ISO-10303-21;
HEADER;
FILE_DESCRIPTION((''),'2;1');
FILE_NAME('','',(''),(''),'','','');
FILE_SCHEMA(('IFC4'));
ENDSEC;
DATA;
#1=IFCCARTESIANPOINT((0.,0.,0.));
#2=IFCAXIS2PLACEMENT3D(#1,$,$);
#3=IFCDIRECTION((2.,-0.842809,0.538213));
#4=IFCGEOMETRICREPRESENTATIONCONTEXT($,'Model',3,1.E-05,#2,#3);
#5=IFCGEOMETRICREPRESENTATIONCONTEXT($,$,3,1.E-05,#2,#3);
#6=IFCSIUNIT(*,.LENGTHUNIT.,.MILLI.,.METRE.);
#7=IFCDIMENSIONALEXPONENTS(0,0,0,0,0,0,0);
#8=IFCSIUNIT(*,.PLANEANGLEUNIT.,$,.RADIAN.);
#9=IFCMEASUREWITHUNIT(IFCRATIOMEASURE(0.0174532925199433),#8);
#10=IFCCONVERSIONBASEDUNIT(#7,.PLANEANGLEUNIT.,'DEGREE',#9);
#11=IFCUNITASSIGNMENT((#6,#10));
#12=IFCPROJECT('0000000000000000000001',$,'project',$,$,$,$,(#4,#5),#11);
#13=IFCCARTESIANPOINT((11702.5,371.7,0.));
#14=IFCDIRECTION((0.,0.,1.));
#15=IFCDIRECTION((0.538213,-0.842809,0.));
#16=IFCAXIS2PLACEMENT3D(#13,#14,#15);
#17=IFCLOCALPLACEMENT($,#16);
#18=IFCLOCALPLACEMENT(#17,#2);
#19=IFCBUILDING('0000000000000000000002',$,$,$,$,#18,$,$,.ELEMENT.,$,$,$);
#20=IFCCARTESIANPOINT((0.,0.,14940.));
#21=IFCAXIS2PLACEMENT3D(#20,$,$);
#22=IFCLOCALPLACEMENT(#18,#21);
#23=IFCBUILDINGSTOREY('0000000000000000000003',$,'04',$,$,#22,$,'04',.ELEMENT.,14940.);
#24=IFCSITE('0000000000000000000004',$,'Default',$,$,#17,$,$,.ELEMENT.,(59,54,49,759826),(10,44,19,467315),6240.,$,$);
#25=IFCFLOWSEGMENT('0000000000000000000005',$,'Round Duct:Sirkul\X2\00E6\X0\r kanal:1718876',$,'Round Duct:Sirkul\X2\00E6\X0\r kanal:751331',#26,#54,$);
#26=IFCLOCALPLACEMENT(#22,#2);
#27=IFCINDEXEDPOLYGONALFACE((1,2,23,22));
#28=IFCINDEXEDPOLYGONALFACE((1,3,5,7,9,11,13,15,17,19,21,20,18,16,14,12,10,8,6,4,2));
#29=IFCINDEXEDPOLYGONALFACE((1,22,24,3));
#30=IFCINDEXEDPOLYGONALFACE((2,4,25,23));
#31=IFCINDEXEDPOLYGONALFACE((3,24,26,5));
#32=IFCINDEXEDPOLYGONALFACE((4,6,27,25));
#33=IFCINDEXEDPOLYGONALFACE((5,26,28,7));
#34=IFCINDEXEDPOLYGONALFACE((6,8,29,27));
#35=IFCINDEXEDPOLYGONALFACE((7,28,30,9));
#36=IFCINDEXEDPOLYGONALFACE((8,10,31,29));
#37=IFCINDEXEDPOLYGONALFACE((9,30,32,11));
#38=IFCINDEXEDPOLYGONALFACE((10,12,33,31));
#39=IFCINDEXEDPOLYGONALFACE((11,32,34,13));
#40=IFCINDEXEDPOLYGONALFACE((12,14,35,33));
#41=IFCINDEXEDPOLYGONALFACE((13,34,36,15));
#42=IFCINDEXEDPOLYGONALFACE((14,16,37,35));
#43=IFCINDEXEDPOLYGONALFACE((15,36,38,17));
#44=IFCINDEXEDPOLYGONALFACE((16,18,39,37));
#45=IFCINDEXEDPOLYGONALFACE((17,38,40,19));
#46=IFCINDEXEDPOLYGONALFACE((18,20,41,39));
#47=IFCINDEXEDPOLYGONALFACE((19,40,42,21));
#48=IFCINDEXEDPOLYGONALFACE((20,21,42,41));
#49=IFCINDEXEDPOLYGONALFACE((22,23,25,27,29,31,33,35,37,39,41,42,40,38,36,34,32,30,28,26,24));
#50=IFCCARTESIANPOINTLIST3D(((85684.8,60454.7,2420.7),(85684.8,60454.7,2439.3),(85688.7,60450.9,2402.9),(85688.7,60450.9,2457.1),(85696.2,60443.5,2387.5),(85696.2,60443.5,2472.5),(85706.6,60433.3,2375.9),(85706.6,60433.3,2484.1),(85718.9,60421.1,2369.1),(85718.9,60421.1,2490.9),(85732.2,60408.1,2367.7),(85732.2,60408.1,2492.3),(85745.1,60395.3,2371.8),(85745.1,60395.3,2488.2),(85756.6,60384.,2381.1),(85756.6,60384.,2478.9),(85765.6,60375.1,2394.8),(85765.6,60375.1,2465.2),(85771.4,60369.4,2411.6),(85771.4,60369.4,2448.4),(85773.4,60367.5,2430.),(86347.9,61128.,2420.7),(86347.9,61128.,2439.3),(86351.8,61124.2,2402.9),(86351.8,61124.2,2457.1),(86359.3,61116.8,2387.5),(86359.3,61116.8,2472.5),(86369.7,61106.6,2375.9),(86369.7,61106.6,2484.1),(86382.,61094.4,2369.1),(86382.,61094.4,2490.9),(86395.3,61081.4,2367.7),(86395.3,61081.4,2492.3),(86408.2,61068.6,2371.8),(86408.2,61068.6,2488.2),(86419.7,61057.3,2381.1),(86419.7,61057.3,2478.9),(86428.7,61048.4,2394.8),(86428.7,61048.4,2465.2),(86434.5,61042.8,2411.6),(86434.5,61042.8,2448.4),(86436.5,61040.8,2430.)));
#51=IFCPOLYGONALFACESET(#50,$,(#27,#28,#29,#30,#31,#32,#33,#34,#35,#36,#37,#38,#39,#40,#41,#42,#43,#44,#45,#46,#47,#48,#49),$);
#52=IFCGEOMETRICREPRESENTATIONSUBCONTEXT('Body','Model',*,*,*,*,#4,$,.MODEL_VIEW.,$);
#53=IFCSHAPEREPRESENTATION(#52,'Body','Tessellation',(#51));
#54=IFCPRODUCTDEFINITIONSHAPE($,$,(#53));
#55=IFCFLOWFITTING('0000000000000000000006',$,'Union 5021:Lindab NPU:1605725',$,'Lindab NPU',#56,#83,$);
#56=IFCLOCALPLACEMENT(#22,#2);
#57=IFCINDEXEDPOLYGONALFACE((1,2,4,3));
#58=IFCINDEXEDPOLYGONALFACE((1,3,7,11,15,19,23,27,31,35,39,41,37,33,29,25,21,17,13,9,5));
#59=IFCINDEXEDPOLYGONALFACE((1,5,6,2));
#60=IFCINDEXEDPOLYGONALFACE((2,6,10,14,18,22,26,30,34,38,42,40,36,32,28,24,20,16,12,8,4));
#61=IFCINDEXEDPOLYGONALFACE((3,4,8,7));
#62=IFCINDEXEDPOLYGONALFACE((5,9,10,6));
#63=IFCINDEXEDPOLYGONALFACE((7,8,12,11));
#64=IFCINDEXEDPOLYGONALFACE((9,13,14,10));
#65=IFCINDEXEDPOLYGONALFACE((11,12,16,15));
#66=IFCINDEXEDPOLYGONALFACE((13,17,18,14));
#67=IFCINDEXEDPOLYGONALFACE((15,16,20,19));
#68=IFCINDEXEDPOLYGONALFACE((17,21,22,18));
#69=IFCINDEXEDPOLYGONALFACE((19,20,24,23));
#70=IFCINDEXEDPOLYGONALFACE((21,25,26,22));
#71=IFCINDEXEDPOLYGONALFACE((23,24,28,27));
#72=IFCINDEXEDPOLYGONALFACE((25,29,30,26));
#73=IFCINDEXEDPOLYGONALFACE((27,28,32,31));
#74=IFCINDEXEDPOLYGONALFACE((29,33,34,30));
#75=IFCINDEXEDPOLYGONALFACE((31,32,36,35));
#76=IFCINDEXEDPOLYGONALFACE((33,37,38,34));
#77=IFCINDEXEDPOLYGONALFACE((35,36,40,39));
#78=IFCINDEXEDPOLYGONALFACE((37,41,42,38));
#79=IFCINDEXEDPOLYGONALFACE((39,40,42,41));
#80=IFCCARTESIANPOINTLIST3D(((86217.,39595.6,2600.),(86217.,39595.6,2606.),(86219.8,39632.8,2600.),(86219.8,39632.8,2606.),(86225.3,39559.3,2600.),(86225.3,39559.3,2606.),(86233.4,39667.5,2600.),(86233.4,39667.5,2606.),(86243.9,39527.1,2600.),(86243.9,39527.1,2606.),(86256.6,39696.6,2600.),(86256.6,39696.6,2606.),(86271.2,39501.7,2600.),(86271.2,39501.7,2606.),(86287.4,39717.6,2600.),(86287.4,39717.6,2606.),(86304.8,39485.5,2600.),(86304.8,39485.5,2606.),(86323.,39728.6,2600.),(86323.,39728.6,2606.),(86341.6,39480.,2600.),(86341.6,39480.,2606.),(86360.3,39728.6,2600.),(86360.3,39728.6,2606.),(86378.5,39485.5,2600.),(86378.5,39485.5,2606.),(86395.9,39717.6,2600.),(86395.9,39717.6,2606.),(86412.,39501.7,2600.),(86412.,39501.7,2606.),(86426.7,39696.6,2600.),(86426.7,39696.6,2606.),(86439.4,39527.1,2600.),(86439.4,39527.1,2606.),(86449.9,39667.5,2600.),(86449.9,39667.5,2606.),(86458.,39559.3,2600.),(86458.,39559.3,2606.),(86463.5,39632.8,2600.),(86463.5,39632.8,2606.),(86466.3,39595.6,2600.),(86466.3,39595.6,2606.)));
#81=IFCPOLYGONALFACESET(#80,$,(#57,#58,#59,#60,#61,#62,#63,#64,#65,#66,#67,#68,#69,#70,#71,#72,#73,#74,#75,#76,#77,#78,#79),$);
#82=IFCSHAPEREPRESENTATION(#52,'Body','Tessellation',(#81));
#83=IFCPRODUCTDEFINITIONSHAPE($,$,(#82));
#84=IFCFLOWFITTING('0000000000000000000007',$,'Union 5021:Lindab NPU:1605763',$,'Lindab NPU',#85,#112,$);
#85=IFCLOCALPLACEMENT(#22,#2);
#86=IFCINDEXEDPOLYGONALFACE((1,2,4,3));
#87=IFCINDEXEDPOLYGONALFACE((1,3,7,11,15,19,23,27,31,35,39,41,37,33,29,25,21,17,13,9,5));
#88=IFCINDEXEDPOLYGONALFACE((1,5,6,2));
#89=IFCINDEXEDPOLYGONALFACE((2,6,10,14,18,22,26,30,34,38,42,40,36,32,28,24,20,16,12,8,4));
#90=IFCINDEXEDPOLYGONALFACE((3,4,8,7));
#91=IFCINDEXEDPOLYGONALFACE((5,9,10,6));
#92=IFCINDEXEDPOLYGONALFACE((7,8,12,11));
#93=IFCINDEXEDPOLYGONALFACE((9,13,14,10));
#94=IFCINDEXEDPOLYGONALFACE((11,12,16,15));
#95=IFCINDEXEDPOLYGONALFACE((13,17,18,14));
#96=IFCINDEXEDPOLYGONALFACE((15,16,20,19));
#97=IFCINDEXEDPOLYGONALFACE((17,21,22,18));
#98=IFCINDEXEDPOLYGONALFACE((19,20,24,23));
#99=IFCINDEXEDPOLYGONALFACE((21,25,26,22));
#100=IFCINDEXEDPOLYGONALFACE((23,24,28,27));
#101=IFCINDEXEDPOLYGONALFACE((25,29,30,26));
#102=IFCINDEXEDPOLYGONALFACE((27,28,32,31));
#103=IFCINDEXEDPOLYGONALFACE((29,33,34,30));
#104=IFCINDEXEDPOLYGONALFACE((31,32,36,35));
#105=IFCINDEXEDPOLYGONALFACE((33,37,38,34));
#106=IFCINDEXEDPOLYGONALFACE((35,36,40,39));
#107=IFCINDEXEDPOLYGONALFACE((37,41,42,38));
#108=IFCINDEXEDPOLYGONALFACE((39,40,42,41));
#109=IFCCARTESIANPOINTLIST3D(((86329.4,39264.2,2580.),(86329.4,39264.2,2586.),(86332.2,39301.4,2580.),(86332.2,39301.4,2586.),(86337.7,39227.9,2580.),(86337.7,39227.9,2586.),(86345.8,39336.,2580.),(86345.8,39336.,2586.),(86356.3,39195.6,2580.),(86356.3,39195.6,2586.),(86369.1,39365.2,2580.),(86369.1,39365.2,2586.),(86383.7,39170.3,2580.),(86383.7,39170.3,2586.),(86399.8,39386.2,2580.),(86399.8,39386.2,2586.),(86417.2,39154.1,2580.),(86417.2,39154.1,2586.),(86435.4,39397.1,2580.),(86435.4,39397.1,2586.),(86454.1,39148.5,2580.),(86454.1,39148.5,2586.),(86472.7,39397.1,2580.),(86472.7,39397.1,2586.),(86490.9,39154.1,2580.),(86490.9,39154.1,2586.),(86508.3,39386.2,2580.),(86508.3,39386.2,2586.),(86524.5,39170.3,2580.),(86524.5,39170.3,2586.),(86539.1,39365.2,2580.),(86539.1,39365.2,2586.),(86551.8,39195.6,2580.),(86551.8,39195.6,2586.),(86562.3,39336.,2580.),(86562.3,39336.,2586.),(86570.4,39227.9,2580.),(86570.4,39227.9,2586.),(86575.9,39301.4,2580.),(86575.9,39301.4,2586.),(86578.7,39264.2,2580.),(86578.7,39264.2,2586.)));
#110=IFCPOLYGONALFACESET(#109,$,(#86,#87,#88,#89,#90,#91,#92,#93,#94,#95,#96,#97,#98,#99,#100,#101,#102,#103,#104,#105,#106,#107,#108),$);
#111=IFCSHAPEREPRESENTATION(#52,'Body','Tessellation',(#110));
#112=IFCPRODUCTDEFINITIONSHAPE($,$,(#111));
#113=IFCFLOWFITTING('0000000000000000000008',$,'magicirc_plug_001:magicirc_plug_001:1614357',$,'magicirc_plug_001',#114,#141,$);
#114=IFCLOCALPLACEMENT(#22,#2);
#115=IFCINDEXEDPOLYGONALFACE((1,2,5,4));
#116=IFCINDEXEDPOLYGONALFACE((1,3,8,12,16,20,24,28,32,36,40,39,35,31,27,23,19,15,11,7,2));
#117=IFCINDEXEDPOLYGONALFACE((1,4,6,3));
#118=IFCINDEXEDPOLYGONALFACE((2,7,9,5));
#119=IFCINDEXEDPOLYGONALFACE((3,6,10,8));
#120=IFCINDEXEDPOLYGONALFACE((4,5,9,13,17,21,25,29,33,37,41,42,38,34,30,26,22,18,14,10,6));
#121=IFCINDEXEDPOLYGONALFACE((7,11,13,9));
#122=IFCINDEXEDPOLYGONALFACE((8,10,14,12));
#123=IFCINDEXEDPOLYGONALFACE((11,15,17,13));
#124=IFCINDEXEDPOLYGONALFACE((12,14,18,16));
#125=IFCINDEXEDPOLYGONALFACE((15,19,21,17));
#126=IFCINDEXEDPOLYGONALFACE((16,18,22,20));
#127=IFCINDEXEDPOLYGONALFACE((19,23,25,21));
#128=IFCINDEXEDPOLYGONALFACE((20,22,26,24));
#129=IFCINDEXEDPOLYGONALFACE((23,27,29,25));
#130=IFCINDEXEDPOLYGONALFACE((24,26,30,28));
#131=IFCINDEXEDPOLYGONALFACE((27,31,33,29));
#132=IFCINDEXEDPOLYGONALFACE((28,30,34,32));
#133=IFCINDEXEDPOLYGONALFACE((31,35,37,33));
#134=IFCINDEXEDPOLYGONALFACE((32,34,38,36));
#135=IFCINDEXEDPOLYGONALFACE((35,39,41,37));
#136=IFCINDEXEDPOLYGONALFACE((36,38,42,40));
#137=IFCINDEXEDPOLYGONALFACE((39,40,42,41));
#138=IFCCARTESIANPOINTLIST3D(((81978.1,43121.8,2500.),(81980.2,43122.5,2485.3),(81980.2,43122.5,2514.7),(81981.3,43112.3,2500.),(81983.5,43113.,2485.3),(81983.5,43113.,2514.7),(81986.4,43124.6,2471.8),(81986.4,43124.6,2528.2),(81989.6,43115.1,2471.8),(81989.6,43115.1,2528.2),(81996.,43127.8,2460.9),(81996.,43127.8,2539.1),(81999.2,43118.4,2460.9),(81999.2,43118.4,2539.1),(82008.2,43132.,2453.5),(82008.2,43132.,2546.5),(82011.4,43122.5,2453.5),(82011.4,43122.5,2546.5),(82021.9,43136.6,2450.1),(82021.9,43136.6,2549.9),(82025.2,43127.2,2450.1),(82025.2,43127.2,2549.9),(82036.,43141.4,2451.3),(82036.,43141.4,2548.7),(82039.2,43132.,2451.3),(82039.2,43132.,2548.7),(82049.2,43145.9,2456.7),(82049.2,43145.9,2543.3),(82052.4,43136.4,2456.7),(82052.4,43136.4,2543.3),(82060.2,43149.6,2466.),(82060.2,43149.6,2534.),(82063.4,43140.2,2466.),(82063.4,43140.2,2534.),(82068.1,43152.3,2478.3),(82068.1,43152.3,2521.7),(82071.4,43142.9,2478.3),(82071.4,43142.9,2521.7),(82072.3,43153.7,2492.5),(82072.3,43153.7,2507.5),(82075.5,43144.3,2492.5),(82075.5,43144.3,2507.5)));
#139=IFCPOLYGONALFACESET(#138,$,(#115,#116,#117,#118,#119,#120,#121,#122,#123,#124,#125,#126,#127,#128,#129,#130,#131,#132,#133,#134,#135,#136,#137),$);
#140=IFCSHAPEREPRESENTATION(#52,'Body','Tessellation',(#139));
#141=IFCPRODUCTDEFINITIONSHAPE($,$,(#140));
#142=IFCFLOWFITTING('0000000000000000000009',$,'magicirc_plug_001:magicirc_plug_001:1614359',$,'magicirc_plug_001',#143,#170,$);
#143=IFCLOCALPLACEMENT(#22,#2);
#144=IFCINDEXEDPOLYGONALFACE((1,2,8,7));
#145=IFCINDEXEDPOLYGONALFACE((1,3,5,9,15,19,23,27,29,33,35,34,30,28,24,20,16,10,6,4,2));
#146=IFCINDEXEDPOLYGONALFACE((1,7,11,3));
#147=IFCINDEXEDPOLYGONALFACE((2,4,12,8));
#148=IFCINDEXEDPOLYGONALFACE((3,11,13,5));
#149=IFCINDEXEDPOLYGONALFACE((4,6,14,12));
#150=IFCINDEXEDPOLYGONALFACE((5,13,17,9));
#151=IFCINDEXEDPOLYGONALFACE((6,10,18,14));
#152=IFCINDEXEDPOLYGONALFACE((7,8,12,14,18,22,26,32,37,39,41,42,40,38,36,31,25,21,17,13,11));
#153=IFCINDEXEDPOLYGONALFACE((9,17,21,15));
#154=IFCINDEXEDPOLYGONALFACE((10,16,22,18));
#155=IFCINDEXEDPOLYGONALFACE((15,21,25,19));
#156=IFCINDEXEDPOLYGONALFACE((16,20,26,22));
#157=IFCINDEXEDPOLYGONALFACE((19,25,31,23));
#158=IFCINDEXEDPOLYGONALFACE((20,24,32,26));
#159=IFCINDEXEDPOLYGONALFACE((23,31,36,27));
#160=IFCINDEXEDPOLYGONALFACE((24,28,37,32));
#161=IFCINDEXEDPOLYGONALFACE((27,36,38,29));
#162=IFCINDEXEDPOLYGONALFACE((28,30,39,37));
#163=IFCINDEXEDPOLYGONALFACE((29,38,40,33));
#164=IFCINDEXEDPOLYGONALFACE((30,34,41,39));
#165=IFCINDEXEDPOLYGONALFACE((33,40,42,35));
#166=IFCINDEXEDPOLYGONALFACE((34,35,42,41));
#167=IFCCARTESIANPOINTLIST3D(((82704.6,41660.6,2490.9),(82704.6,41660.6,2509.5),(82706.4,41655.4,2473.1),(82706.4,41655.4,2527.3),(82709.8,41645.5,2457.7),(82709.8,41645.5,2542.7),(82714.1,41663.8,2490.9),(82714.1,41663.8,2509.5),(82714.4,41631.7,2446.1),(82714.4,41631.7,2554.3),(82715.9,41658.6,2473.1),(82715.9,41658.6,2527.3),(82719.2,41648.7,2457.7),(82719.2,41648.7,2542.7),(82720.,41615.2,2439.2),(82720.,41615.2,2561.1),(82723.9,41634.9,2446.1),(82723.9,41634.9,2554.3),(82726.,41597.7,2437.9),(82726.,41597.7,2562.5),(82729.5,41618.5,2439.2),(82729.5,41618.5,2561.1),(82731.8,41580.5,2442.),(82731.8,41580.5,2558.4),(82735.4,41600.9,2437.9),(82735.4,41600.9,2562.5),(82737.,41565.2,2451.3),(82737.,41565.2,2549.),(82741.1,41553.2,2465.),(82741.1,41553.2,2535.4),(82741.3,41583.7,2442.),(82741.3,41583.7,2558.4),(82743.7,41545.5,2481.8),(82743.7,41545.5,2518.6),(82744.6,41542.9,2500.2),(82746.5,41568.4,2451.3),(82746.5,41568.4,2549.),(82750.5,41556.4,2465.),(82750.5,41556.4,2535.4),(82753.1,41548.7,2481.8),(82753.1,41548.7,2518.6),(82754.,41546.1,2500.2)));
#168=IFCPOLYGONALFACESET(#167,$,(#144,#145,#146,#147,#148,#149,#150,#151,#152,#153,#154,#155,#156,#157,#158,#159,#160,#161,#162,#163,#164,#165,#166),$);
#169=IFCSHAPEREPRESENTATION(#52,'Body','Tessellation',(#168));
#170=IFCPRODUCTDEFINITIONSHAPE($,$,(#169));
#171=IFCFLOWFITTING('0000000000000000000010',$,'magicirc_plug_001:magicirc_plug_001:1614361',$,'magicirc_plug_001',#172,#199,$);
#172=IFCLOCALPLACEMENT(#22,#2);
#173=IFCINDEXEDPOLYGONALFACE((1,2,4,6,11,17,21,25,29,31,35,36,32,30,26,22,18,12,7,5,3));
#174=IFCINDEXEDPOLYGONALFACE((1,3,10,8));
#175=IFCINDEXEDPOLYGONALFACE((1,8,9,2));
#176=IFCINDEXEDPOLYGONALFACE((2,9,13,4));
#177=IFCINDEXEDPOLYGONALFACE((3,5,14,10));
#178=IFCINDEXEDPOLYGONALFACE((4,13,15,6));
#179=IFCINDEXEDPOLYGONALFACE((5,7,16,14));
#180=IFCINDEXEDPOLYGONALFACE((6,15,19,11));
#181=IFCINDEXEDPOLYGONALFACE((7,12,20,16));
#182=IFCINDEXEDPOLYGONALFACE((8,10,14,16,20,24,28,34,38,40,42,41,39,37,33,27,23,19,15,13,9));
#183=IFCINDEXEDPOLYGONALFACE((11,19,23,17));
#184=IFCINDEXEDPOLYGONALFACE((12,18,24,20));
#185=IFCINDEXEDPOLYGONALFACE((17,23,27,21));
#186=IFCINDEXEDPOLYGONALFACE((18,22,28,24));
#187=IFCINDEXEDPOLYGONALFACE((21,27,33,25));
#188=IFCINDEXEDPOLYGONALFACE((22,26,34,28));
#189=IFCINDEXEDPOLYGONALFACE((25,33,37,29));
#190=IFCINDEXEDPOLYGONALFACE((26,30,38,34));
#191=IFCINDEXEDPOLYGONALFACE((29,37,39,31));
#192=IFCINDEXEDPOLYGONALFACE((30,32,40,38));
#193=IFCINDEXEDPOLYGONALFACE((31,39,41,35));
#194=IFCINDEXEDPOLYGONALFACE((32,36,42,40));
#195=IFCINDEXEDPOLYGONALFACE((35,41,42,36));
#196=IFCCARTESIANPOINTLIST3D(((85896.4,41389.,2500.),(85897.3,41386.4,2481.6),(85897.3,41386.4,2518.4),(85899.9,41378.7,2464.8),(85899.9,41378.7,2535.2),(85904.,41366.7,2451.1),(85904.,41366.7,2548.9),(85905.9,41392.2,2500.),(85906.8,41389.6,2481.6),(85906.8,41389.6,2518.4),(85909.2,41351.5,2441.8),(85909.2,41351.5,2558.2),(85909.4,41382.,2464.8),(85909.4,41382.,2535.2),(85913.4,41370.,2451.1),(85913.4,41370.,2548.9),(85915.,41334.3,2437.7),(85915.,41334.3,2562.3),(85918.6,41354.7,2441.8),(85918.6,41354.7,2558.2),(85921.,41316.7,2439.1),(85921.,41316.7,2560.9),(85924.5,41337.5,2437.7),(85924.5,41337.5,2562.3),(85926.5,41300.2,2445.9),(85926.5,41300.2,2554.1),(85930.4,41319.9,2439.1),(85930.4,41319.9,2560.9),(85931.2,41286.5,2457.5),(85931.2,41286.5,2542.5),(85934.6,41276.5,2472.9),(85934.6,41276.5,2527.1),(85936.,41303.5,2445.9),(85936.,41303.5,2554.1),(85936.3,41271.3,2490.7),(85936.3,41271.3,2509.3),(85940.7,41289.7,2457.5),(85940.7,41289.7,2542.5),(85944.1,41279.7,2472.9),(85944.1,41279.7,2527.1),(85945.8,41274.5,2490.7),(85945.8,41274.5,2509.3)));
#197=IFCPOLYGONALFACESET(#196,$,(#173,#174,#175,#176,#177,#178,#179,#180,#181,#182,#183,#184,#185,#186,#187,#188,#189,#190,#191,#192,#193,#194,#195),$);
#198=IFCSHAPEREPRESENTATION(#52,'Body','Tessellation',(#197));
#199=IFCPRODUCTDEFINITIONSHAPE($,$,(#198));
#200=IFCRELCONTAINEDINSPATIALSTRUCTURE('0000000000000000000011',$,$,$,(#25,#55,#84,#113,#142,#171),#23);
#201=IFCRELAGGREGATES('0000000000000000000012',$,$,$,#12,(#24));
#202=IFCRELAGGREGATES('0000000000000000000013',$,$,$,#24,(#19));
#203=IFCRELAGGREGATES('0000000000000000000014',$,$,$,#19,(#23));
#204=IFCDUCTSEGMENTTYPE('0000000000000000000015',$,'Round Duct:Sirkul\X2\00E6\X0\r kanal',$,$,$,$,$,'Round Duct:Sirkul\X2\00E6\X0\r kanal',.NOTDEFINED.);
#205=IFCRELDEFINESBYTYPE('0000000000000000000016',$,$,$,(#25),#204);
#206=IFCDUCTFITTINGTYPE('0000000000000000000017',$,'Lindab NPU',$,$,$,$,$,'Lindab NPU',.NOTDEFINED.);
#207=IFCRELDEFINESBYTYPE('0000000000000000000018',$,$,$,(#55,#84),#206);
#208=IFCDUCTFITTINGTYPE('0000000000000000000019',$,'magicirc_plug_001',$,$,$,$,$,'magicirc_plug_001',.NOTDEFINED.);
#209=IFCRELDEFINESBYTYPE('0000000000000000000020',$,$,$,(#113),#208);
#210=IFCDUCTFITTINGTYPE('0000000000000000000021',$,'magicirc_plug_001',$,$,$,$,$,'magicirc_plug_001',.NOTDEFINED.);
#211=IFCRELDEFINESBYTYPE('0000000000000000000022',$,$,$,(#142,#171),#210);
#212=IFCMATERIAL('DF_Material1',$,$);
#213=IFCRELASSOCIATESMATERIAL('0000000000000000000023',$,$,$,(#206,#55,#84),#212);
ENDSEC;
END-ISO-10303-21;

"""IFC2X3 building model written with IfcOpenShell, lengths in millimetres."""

from ifc_helpers import new_model, entity, si_unit, converted_unit, direction, frame, frame_2d, origin, origin_2d_with_axis, place, context, subcontext, project, spatial, circle, extrude, source, transform, mapped, material, type_object, type_shapes, element, save


model = new_model("IFC2X3")

# Units and contexts
model_context = context("Model", 3, precision=1e-05, world=origin(), true_north=direction((2.0, -0.842809, 0.538213)))
context_of_model = context(None, 3, precision=1e-05, world=origin(), true_north=direction((2.0, -0.842809, 0.538213)))
body_context = subcontext(model_context, "Body", "Model", "MODEL_VIEW")
ifc_project = project(units=[si_unit("LENGTHUNIT", "METRE", prefix="MILLI"), converted_unit("PLANEANGLEUNIT", "DEGREE", entity("IfcRatioMeasure", 0.0174532925199433), si_unit("PLANEANGLEUNIT", "RADIAN"), dimensions=[0, 0, 0, 0, 0, 0, 0])], contexts=[model_context, context_of_model])

# Site, building, storey
site_placement = place(None, frame((11702.5, 371.7, 0.0), z_axis=(0.0, 0.0, 1.0), x_axis=(0.538213, -0.842809, 0.0)))
site = spatial("IfcSite", under=ifc_project, at=site_placement, Name="Default", CompositionType="ELEMENT", RefLatitude=(59, 54, 49, 759826), RefLongitude=(10, 44, 19, 467315), RefElevation=6240.0)
building_placement = place(site_placement, origin())
building = spatial("IfcBuilding", under=site, at=building_placement, CompositionType="ELEMENT")
storey_placement = place(building_placement, frame((0.0, 0.0, 14940.0)))
storey = spatial("IfcBuildingStorey", under=building, at=storey_placement, Name="04", LongName="04", CompositionType="ELEMENT", Elevation=14940.0)

# Flow segment
duct_segment_type = type_object("IfcDuctSegmentType", Name="Round Duct:Sirkulær kanal", ElementType="Round Duct:Sirkulær kanal", PredefinedType="NOTDEFINED")
flow_segment_1_placement = place(storey_placement, origin())
element("IfcFlowSegment", 1, at=flow_segment_1_placement, inside=storey, type_object=duct_segment_type, Name="Round Duct:Sirkulær kanal:1718876", ObjectType="Round Duct:Sirkulær kanal:751331", context=body_context, shape_type="SweptSolid", body=[
    extrude(circle(Radius=62.5, at=origin_2d_with_axis()), frame((85728.8, 60411.4, 2430.0), z_axis=(0.701682, 0.71249, 0.0), x_axis=(0.71249, -0.701682, 0.0)), (0.0, 0.0, 1.0), 945.0),
])

# Flow fittings
ifc_material = material(Name="DF_Material1")
duct_fitting_type_1 = type_object("IfcDuctFittingType", Name="Lindab NPU", ElementType="Lindab NPU", PredefinedType="NOTDEFINED", material=ifc_material)
shared_shape_1 = source(origin(), body_context, "Body", "SweptSolid", [
    extrude(circle(Radius=125.0, at=frame_2d((0.0, 0.0), x_axis=(1.0, 0.0))), frame((0.0, 0.0, 0.0), z_axis=(1.0, 0.0, 0.0), x_axis=(0.0, 1.0, 0.0)), (0.0, 0.0, 1.0), 6.0),
])
type_shapes(duct_fitting_type_1, [shared_shape_1])
for number, where, z_axis, x_axis, name in (
    (2, (86341.6, 39605.0, 2600.0), (1.0, 0.0, 0.0), (0.0, 0.0, 1.0), "Union 5021:Lindab NPU:1605725"),
    (3, (86454.1, 39273.5, 2580.0), (1.0, 0.0, 0.0), (0.0, 0.0, 1.0), "Union 5021:Lindab NPU:1605763"),
):
    element("IfcFlowFitting", number, at=place(storey_placement, frame(where, z_axis=z_axis, x_axis=x_axis)), inside=storey, type_object=duct_fitting_type_1, material=ifc_material, Name=name, ObjectType="Lindab NPU", context=body_context, shape_type="MappedRepresentation", body=[
        mapped(shared_shape_1, transform((0.0, 0.0, 0.0), scale=1.0)),
    ])
duct_fitting_type_2 = type_object("IfcDuctFittingType", Name="magicirc_plug_001", ElementType="magicirc_plug_001", PredefinedType="NOTDEFINED")
shared_shape_2 = source(origin(), body_context, "Body", "SweptSolid", [
    extrude(circle(Radius=50.0, at=frame_2d((0.0, 0.0), x_axis=(1.0, 0.0))), frame((0.0, 0.0, 0.0), z_axis=(1.0, 0.0, 0.0), x_axis=(0.0, 1.0, 0.0)), (0.0, 0.0, 1.0), 10.0),
])
type_shapes(duct_fitting_type_2, [shared_shape_2])
flow_fitting_placement = place(storey_placement, frame((82028.7, 43128.4, 2500.0), z_axis=(0.0, 0.0, 1.0), x_axis=(-0.321274, 0.946986, 0.0)))
element("IfcFlowFitting", 4, at=flow_fitting_placement, inside=storey, type_object=duct_fitting_type_2, Name="magicirc_plug_001:magicirc_plug_001:1614357", ObjectType="magicirc_plug_001", context=body_context, shape_type="MappedRepresentation", body=[
    mapped(shared_shape_2, transform((0.0, 0.0, 0.0), scale=1.0)),
])
duct_fitting_type_3 = type_object("IfcDuctFittingType", Name="magicirc_plug_001", ElementType="magicirc_plug_001", PredefinedType="NOTDEFINED")
shared_shape_3 = source(origin(), body_context, "Body", "SweptSolid", [
    extrude(circle(Radius=62.5, at=frame_2d((0.0, 0.0), x_axis=(1.0, 0.0))), frame((0.0, 0.0, 0.0), z_axis=(1.0, 0.0, 0.0), x_axis=(0.0, 1.0, 0.0)), (0.0, 0.0, 1.0), 10.0),
])
type_shapes(duct_fitting_type_3, [shared_shape_3])
for number, where, z_axis, x_axis, name in (
    (5, (82733.9, 41605.3, 2500.2), (0.0, 0.0, 1.0), (-0.946986, -0.321274, 0.0), "magicirc_plug_001:magicirc_plug_001:1614359"),
    (6, (85916.5, 41329.8, 2500.0), (0.0, 0.0, 1.0), (0.946986, 0.321274, 0.0), "magicirc_plug_001:magicirc_plug_001:1614361"),
):
    element("IfcFlowFitting", number, at=place(storey_placement, frame(where, z_axis=z_axis, x_axis=x_axis)), inside=storey, type_object=duct_fitting_type_3, Name=name, ObjectType="magicirc_plug_001", context=body_context, shape_type="MappedRepresentation", body=[
        mapped(shared_shape_3, transform((0.0, 0.0, 0.0), scale=1.0)),
    ])

save(model, "model.ifc")
